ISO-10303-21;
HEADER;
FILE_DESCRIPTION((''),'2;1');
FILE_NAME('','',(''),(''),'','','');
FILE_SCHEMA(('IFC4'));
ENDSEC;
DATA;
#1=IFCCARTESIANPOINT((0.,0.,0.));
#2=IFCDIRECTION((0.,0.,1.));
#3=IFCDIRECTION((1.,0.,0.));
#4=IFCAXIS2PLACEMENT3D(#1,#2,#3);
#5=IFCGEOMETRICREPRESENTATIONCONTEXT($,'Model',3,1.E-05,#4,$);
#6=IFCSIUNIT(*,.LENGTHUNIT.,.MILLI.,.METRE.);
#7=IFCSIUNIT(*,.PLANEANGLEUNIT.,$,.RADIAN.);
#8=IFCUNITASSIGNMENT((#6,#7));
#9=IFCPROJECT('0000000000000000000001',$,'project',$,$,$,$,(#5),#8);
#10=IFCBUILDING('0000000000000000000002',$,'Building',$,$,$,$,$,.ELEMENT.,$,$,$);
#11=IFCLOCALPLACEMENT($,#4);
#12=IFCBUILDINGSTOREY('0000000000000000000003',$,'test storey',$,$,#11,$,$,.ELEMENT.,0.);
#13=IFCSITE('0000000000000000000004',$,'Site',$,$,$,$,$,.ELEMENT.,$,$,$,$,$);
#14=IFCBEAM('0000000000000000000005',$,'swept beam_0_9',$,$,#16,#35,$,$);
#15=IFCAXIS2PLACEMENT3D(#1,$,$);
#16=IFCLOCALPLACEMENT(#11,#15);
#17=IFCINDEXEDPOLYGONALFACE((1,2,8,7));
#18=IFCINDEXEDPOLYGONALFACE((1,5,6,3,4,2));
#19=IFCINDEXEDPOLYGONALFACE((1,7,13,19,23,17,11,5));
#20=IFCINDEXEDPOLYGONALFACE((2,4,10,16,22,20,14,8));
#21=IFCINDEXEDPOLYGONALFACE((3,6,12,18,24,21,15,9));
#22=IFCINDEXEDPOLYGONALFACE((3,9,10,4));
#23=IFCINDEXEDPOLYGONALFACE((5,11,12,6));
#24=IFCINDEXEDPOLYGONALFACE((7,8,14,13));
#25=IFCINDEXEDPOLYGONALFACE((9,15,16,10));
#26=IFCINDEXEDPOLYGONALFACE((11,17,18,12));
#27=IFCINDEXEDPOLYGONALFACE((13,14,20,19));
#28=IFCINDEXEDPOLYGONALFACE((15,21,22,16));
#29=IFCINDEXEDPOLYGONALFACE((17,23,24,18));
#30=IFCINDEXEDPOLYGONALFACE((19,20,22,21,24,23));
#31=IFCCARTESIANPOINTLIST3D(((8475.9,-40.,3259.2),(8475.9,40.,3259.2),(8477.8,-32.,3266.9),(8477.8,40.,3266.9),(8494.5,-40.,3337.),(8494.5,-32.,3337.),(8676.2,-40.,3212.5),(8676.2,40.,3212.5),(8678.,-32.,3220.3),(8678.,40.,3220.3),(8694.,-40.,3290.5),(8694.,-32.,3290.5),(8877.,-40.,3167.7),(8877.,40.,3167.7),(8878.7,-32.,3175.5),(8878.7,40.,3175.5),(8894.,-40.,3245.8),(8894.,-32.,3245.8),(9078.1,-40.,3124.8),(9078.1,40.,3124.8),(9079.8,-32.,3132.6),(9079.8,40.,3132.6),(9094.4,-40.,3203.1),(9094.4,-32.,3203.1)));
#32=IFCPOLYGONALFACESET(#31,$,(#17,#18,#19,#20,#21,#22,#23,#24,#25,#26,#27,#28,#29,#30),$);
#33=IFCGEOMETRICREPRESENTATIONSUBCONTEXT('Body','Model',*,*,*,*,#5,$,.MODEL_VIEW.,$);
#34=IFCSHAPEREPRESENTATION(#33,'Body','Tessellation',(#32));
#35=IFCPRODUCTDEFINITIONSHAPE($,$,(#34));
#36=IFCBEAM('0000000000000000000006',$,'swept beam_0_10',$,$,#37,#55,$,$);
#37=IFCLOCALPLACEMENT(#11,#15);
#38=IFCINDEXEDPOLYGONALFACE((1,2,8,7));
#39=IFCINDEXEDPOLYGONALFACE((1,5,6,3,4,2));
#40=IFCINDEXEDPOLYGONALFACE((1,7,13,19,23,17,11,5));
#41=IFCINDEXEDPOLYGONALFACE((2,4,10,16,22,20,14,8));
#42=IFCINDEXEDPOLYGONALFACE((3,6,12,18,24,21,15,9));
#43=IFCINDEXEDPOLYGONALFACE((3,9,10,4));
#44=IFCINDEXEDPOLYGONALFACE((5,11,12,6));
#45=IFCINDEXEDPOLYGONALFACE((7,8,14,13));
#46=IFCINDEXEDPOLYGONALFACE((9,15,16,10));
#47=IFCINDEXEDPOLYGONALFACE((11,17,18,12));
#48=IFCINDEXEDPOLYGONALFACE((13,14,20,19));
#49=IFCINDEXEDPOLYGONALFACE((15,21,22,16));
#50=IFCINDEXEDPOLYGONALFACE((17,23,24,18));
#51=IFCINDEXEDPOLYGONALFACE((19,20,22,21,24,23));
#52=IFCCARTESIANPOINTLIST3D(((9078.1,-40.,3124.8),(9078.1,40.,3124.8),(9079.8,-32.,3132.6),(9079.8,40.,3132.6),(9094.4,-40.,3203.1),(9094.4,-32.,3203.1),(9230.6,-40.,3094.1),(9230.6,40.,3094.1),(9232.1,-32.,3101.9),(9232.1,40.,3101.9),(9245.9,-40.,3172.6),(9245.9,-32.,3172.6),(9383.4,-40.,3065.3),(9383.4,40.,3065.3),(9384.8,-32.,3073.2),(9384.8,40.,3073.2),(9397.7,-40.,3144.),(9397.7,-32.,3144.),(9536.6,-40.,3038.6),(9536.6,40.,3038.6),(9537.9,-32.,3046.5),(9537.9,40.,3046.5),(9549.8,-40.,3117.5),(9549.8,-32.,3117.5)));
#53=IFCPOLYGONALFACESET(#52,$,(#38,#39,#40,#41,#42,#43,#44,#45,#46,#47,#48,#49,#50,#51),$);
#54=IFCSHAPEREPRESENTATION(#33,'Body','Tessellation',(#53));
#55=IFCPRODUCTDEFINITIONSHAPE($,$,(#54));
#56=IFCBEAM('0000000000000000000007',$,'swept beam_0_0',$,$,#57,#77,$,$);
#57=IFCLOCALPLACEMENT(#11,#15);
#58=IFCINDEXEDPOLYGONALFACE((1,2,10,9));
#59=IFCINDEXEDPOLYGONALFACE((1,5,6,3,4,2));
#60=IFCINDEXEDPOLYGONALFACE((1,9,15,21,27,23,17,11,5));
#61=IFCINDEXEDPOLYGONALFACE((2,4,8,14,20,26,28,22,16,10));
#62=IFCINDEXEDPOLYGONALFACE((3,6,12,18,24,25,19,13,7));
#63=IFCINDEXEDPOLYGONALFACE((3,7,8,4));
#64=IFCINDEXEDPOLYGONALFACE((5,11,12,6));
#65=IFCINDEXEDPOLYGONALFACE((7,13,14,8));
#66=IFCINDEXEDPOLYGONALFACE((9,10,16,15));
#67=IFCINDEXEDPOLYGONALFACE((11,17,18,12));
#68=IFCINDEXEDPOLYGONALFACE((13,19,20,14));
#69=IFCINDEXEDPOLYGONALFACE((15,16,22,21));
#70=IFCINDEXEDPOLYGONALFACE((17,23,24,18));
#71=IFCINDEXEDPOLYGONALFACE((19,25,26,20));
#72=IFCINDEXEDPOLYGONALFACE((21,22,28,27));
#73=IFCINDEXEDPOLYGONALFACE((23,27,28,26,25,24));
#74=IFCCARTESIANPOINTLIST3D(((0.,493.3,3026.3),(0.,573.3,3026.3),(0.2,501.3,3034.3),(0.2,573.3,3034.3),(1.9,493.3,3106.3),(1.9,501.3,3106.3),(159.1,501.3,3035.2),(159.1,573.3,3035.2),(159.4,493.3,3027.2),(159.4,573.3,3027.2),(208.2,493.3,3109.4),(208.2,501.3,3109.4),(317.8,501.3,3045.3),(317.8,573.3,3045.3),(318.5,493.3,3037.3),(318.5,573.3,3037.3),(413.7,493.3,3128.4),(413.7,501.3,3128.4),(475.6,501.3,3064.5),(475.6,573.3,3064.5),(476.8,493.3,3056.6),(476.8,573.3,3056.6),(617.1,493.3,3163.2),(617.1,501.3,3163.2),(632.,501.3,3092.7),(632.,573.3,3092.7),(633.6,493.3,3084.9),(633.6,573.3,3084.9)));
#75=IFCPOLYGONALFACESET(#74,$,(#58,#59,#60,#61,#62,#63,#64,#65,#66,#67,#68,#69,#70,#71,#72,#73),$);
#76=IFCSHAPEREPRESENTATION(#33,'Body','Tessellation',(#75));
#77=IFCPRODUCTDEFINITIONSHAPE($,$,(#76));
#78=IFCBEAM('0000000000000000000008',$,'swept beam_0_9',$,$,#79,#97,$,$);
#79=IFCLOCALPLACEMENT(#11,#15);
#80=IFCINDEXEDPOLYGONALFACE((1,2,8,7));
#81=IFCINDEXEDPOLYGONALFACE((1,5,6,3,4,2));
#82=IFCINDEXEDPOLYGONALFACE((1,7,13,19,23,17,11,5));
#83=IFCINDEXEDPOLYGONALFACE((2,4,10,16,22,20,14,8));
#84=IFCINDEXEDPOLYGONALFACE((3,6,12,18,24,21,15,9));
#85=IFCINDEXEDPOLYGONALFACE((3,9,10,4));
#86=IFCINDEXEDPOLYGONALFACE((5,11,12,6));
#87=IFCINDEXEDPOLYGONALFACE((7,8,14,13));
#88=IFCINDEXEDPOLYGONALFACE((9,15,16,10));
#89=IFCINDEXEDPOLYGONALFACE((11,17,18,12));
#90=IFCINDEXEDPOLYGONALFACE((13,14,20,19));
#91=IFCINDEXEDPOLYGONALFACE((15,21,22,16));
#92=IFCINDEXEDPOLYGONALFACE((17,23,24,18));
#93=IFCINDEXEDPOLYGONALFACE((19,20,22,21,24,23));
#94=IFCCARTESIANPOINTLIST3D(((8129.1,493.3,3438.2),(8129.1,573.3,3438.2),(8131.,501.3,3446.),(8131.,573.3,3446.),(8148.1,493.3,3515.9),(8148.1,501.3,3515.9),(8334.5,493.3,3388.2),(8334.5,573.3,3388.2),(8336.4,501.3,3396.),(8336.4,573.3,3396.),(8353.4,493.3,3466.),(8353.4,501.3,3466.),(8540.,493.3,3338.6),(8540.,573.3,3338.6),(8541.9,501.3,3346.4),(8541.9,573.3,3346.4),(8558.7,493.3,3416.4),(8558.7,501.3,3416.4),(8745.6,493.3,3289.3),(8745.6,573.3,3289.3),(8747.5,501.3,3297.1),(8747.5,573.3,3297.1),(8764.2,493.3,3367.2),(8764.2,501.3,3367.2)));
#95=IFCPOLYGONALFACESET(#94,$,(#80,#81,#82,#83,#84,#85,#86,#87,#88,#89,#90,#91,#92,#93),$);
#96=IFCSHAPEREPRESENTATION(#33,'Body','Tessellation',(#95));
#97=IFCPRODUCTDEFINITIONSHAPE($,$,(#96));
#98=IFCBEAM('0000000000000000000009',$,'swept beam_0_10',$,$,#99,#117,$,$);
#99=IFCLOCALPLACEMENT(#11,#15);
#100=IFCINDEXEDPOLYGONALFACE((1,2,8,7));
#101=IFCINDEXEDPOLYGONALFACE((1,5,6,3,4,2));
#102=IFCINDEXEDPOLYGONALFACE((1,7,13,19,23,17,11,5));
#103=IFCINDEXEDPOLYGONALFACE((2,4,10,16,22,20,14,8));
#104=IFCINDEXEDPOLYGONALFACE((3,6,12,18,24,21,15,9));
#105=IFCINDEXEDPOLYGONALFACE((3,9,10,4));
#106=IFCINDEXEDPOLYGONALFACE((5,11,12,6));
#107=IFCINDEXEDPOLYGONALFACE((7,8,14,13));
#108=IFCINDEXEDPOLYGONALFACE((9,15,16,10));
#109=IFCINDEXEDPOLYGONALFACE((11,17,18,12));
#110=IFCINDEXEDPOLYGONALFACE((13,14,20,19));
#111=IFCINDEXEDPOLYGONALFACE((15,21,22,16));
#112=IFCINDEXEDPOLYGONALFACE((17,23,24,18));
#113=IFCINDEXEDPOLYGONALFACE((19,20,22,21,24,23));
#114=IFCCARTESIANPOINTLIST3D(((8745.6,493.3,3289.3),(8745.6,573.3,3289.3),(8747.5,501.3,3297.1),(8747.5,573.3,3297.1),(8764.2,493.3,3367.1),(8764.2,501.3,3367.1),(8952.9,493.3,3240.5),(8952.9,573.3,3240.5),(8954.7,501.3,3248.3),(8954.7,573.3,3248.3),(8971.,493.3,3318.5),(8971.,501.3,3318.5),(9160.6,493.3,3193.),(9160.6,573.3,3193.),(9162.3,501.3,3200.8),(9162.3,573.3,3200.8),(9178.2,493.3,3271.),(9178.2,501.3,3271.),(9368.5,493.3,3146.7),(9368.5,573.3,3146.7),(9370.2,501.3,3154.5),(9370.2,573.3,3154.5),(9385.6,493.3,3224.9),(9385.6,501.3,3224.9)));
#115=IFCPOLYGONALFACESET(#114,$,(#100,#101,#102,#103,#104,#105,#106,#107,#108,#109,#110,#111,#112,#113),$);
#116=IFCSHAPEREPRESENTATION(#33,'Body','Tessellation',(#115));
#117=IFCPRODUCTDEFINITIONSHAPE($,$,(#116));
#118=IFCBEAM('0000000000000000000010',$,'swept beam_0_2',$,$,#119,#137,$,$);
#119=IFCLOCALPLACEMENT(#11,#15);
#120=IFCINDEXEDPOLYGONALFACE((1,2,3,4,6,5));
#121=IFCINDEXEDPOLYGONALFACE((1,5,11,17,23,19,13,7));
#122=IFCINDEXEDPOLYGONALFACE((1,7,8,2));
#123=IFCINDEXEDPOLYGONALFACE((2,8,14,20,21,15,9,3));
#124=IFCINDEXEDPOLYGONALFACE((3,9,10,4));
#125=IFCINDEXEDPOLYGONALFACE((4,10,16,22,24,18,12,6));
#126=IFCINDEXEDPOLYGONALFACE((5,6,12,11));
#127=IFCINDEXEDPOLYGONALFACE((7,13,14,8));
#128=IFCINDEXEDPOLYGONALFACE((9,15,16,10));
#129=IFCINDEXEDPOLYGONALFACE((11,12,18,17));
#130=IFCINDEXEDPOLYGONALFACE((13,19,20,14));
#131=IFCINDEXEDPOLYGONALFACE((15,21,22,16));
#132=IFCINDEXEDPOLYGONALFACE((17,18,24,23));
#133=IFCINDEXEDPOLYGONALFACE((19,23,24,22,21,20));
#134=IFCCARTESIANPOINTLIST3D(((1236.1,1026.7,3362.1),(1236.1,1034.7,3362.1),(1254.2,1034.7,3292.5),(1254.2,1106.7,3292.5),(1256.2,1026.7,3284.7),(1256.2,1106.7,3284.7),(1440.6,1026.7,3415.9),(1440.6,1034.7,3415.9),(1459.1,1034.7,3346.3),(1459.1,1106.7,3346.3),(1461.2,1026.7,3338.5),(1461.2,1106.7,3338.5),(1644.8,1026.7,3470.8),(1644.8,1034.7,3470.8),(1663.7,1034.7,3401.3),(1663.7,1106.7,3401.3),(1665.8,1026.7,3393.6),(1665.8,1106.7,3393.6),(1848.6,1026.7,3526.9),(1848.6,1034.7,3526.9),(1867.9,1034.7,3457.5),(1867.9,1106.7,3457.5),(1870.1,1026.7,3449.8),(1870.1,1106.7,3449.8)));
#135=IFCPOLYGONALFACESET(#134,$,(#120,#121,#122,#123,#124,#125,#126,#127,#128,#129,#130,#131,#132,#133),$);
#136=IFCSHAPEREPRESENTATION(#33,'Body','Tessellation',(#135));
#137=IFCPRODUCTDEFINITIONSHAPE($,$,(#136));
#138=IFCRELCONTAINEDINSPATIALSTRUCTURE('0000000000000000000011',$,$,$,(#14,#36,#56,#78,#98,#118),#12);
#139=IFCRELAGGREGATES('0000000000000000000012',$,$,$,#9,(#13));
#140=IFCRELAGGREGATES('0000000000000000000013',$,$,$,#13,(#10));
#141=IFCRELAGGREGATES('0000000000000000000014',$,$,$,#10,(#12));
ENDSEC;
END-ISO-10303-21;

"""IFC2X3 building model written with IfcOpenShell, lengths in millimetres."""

from ifc_helpers import new_model, entity, si_unit, origin_with_axes, place, context, subcontext, project, spatial, element, save


model = new_model("IFC2X3")

# Units and contexts
model_context = context("Model", 3, precision=1e-05, world=origin_with_axes())
body_context = subcontext(model_context, "Body", "Model", "MODEL_VIEW")
ifc_project = project(units=[si_unit("LENGTHUNIT", "METRE", prefix="MILLI"), si_unit("PLANEANGLEUNIT", "RADIAN")], contexts=[model_context])

# Site, building, storey
site = spatial("IfcSite", under=ifc_project, Name="Site", CompositionType="ELEMENT")
building = spatial("IfcBuilding", under=site, Name="Building", CompositionType="ELEMENT")
storey_placement = place(None, origin_with_axes())
storey = spatial("IfcBuildingStorey", under=building, at=storey_placement, Name="test storey", CompositionType="ELEMENT", Elevation=0.0)

# Beams
beam_1_placement = place(storey_placement, origin_with_axes())
element("IfcBeam", 1, at=beam_1_placement, inside=storey, Name="swept beam_0_9", context=body_context, shape_type="SweptSolid", body=[
    entity("IfcRevolvedAreaSolid", entity("IfcArbitraryClosedProfileDef", "AREA", None, entity("IfcPolyline", [entity("IfcCartesianPoint", [-80.0, 40.0]), entity("IfcCartesianPoint", [-80.0, 32.0]), entity("IfcCartesianPoint", [-8.0, 32.0]), entity("IfcCartesianPoint", [-8.0, -40.0]), entity("IfcCartesianPoint", [0.0, -40.0]), entity("IfcCartesianPoint", [0.0, 40.0]), entity("IfcCartesianPoint", [-80.0, 40.0])])), entity("IfcAxis2Placement3D", entity("IfcCartesianPoint", [8475.9, 0.0, 3259.2]), entity("IfcDirection", [-0.9728, 0.0, 0.2316]), entity("IfcDirection", [-0.2316, 0.0, -0.9728])), entity("IfcAxis1Placement", entity("IfcCartesianPoint", [-21723.0, 0.0, 0.0]), entity("IfcDirection", [0.0, 1.0, 0.0])), 0.028404),
])
beam_2_placement = place(storey_placement, origin_with_axes())
element("IfcBeam", 2, at=beam_2_placement, inside=storey, Name="swept beam_0_10", context=body_context, shape_type="SweptSolid", body=[
    entity("IfcRevolvedAreaSolid", entity("IfcArbitraryClosedProfileDef", "AREA", None, entity("IfcPolyline", [entity("IfcCartesianPoint", [-80.0, 40.0]), entity("IfcCartesianPoint", [-80.0, 32.0]), entity("IfcCartesianPoint", [-8.0, 32.0]), entity("IfcCartesianPoint", [-8.0, -40.0]), entity("IfcCartesianPoint", [0.0, -40.0]), entity("IfcCartesianPoint", [0.0, 40.0]), entity("IfcCartesianPoint", [-80.0, 40.0])])), entity("IfcAxis2Placement3D", entity("IfcCartesianPoint", [9078.1, 0.0, 3124.8]), entity("IfcDirection", [-0.979, 0.0, 0.2039]), entity("IfcDirection", [-0.2039, 0.0, -0.979])), entity("IfcAxis1Placement", entity("IfcCartesianPoint", [-11908.9, 0.0, 0.0]), entity("IfcDirection", [0.0, 1.0, 0.0])), 0.039176),
])
beam_3_placement = place(storey_placement, origin_with_axes())
element("IfcBeam", 3, at=beam_3_placement, inside=storey, Name="swept beam_0_0", context=body_context, shape_type="SweptSolid", body=[
    entity("IfcRevolvedAreaSolid", entity("IfcArbitraryClosedProfileDef", "AREA", None, entity("IfcPolyline", [entity("IfcCartesianPoint", [-80.0, 40.0]), entity("IfcCartesianPoint", [-80.0, 32.0]), entity("IfcCartesianPoint", [-8.0, 32.0]), entity("IfcCartesianPoint", [-8.0, -40.0]), entity("IfcCartesianPoint", [0.0, -40.0]), entity("IfcCartesianPoint", [0.0, 40.0]), entity("IfcCartesianPoint", [-80.0, 40.0])])), entity("IfcAxis2Placement3D", entity("IfcCartesianPoint", [0.0, 533.3, 3026.3]), entity("IfcDirection", [-0.9997, 0.0, 0.0233]), entity("IfcDirection", [-0.0233, 0.0, -0.9997])), entity("IfcAxis1Placement", entity("IfcCartesianPoint", [-2760.3, 0.0, 0.0]), entity("IfcDirection", [0.0, 1.0, 0.0])), 0.231047),
])
beam_4_placement = place(storey_placement, origin_with_axes())
element("IfcBeam", 4, at=beam_4_placement, inside=storey, Name="swept beam_0_9", context=body_context, shape_type="SweptSolid", body=[
    entity("IfcRevolvedAreaSolid", entity("IfcArbitraryClosedProfileDef", "AREA", None, entity("IfcPolyline", [entity("IfcCartesianPoint", [-80.0, 40.0]), entity("IfcCartesianPoint", [-80.0, 32.0]), entity("IfcCartesianPoint", [-8.0, 32.0]), entity("IfcCartesianPoint", [-8.0, -40.0]), entity("IfcCartesianPoint", [0.0, -40.0]), entity("IfcCartesianPoint", [0.0, 40.0]), entity("IfcCartesianPoint", [-80.0, 40.0])])), entity("IfcAxis2Placement3D", entity("IfcCartesianPoint", [8129.1, 533.3, 3438.2]), entity("IfcDirection", [-0.9714, 0.0, 0.2376]), entity("IfcDirection", [-0.2376, 0.0, -0.9714])), entity("IfcAxis1Placement", entity("IfcCartesianPoint", [-109364.5, 0.0, 0.0]), entity("IfcDirection", [0.0, 1.0, 0.0])), 0.005799),
])
beam_5_placement = place(storey_placement, origin_with_axes())
element("IfcBeam", 5, at=beam_5_placement, inside=storey, Name="swept beam_0_10", context=body_context, shape_type="SweptSolid", body=[
    entity("IfcRevolvedAreaSolid", entity("IfcArbitraryClosedProfileDef", "AREA", None, entity("IfcPolyline", [entity("IfcCartesianPoint", [-80.0, 40.0]), entity("IfcCartesianPoint", [-80.0, 32.0]), entity("IfcCartesianPoint", [-8.0, 32.0]), entity("IfcCartesianPoint", [-8.0, -40.0]), entity("IfcCartesianPoint", [0.0, -40.0]), entity("IfcCartesianPoint", [0.0, 40.0]), entity("IfcCartesianPoint", [-80.0, 40.0])])), entity("IfcAxis2Placement3D", entity("IfcCartesianPoint", [8745.6, 533.3, 3289.3]), entity("IfcDirection", [-0.9727, 0.0, 0.232]), entity("IfcDirection", [-0.232, 0.0, -0.9727])), entity("IfcAxis1Placement", entity("IfcCartesianPoint", [-35056.5, 0.0, 0.0]), entity("IfcDirection", [0.0, 1.0, 0.0])), 0.018228),
])
beam_6_placement = place(storey_placement, origin_with_axes())
element("IfcBeam", 6, at=beam_6_placement, inside=storey, Name="swept beam_0_2", context=body_context, shape_type="SweptSolid", body=[
    entity("IfcRevolvedAreaSolid", entity("IfcArbitraryClosedProfileDef", "AREA", None, entity("IfcPolyline", [entity("IfcCartesianPoint", [-80.0, 40.0]), entity("IfcCartesianPoint", [-80.0, 32.0]), entity("IfcCartesianPoint", [-8.0, 32.0]), entity("IfcCartesianPoint", [-8.0, -40.0]), entity("IfcCartesianPoint", [0.0, -40.0]), entity("IfcCartesianPoint", [0.0, 40.0]), entity("IfcCartesianPoint", [-80.0, 40.0])])), entity("IfcAxis2Placement3D", entity("IfcCartesianPoint", [1256.2, 1066.7, 3284.7]), entity("IfcDirection", [-0.9679, 0.0, -0.2512]), entity("IfcDirection", [0.2512, 0.0, -0.9679])), entity("IfcAxis1Placement", entity("IfcCartesianPoint", [-35957.3, 0.0, 0.0]), entity("IfcDirection", [0.0, 1.0, 0.0])), 0.017679),
])

save(model, "model.ifc")
